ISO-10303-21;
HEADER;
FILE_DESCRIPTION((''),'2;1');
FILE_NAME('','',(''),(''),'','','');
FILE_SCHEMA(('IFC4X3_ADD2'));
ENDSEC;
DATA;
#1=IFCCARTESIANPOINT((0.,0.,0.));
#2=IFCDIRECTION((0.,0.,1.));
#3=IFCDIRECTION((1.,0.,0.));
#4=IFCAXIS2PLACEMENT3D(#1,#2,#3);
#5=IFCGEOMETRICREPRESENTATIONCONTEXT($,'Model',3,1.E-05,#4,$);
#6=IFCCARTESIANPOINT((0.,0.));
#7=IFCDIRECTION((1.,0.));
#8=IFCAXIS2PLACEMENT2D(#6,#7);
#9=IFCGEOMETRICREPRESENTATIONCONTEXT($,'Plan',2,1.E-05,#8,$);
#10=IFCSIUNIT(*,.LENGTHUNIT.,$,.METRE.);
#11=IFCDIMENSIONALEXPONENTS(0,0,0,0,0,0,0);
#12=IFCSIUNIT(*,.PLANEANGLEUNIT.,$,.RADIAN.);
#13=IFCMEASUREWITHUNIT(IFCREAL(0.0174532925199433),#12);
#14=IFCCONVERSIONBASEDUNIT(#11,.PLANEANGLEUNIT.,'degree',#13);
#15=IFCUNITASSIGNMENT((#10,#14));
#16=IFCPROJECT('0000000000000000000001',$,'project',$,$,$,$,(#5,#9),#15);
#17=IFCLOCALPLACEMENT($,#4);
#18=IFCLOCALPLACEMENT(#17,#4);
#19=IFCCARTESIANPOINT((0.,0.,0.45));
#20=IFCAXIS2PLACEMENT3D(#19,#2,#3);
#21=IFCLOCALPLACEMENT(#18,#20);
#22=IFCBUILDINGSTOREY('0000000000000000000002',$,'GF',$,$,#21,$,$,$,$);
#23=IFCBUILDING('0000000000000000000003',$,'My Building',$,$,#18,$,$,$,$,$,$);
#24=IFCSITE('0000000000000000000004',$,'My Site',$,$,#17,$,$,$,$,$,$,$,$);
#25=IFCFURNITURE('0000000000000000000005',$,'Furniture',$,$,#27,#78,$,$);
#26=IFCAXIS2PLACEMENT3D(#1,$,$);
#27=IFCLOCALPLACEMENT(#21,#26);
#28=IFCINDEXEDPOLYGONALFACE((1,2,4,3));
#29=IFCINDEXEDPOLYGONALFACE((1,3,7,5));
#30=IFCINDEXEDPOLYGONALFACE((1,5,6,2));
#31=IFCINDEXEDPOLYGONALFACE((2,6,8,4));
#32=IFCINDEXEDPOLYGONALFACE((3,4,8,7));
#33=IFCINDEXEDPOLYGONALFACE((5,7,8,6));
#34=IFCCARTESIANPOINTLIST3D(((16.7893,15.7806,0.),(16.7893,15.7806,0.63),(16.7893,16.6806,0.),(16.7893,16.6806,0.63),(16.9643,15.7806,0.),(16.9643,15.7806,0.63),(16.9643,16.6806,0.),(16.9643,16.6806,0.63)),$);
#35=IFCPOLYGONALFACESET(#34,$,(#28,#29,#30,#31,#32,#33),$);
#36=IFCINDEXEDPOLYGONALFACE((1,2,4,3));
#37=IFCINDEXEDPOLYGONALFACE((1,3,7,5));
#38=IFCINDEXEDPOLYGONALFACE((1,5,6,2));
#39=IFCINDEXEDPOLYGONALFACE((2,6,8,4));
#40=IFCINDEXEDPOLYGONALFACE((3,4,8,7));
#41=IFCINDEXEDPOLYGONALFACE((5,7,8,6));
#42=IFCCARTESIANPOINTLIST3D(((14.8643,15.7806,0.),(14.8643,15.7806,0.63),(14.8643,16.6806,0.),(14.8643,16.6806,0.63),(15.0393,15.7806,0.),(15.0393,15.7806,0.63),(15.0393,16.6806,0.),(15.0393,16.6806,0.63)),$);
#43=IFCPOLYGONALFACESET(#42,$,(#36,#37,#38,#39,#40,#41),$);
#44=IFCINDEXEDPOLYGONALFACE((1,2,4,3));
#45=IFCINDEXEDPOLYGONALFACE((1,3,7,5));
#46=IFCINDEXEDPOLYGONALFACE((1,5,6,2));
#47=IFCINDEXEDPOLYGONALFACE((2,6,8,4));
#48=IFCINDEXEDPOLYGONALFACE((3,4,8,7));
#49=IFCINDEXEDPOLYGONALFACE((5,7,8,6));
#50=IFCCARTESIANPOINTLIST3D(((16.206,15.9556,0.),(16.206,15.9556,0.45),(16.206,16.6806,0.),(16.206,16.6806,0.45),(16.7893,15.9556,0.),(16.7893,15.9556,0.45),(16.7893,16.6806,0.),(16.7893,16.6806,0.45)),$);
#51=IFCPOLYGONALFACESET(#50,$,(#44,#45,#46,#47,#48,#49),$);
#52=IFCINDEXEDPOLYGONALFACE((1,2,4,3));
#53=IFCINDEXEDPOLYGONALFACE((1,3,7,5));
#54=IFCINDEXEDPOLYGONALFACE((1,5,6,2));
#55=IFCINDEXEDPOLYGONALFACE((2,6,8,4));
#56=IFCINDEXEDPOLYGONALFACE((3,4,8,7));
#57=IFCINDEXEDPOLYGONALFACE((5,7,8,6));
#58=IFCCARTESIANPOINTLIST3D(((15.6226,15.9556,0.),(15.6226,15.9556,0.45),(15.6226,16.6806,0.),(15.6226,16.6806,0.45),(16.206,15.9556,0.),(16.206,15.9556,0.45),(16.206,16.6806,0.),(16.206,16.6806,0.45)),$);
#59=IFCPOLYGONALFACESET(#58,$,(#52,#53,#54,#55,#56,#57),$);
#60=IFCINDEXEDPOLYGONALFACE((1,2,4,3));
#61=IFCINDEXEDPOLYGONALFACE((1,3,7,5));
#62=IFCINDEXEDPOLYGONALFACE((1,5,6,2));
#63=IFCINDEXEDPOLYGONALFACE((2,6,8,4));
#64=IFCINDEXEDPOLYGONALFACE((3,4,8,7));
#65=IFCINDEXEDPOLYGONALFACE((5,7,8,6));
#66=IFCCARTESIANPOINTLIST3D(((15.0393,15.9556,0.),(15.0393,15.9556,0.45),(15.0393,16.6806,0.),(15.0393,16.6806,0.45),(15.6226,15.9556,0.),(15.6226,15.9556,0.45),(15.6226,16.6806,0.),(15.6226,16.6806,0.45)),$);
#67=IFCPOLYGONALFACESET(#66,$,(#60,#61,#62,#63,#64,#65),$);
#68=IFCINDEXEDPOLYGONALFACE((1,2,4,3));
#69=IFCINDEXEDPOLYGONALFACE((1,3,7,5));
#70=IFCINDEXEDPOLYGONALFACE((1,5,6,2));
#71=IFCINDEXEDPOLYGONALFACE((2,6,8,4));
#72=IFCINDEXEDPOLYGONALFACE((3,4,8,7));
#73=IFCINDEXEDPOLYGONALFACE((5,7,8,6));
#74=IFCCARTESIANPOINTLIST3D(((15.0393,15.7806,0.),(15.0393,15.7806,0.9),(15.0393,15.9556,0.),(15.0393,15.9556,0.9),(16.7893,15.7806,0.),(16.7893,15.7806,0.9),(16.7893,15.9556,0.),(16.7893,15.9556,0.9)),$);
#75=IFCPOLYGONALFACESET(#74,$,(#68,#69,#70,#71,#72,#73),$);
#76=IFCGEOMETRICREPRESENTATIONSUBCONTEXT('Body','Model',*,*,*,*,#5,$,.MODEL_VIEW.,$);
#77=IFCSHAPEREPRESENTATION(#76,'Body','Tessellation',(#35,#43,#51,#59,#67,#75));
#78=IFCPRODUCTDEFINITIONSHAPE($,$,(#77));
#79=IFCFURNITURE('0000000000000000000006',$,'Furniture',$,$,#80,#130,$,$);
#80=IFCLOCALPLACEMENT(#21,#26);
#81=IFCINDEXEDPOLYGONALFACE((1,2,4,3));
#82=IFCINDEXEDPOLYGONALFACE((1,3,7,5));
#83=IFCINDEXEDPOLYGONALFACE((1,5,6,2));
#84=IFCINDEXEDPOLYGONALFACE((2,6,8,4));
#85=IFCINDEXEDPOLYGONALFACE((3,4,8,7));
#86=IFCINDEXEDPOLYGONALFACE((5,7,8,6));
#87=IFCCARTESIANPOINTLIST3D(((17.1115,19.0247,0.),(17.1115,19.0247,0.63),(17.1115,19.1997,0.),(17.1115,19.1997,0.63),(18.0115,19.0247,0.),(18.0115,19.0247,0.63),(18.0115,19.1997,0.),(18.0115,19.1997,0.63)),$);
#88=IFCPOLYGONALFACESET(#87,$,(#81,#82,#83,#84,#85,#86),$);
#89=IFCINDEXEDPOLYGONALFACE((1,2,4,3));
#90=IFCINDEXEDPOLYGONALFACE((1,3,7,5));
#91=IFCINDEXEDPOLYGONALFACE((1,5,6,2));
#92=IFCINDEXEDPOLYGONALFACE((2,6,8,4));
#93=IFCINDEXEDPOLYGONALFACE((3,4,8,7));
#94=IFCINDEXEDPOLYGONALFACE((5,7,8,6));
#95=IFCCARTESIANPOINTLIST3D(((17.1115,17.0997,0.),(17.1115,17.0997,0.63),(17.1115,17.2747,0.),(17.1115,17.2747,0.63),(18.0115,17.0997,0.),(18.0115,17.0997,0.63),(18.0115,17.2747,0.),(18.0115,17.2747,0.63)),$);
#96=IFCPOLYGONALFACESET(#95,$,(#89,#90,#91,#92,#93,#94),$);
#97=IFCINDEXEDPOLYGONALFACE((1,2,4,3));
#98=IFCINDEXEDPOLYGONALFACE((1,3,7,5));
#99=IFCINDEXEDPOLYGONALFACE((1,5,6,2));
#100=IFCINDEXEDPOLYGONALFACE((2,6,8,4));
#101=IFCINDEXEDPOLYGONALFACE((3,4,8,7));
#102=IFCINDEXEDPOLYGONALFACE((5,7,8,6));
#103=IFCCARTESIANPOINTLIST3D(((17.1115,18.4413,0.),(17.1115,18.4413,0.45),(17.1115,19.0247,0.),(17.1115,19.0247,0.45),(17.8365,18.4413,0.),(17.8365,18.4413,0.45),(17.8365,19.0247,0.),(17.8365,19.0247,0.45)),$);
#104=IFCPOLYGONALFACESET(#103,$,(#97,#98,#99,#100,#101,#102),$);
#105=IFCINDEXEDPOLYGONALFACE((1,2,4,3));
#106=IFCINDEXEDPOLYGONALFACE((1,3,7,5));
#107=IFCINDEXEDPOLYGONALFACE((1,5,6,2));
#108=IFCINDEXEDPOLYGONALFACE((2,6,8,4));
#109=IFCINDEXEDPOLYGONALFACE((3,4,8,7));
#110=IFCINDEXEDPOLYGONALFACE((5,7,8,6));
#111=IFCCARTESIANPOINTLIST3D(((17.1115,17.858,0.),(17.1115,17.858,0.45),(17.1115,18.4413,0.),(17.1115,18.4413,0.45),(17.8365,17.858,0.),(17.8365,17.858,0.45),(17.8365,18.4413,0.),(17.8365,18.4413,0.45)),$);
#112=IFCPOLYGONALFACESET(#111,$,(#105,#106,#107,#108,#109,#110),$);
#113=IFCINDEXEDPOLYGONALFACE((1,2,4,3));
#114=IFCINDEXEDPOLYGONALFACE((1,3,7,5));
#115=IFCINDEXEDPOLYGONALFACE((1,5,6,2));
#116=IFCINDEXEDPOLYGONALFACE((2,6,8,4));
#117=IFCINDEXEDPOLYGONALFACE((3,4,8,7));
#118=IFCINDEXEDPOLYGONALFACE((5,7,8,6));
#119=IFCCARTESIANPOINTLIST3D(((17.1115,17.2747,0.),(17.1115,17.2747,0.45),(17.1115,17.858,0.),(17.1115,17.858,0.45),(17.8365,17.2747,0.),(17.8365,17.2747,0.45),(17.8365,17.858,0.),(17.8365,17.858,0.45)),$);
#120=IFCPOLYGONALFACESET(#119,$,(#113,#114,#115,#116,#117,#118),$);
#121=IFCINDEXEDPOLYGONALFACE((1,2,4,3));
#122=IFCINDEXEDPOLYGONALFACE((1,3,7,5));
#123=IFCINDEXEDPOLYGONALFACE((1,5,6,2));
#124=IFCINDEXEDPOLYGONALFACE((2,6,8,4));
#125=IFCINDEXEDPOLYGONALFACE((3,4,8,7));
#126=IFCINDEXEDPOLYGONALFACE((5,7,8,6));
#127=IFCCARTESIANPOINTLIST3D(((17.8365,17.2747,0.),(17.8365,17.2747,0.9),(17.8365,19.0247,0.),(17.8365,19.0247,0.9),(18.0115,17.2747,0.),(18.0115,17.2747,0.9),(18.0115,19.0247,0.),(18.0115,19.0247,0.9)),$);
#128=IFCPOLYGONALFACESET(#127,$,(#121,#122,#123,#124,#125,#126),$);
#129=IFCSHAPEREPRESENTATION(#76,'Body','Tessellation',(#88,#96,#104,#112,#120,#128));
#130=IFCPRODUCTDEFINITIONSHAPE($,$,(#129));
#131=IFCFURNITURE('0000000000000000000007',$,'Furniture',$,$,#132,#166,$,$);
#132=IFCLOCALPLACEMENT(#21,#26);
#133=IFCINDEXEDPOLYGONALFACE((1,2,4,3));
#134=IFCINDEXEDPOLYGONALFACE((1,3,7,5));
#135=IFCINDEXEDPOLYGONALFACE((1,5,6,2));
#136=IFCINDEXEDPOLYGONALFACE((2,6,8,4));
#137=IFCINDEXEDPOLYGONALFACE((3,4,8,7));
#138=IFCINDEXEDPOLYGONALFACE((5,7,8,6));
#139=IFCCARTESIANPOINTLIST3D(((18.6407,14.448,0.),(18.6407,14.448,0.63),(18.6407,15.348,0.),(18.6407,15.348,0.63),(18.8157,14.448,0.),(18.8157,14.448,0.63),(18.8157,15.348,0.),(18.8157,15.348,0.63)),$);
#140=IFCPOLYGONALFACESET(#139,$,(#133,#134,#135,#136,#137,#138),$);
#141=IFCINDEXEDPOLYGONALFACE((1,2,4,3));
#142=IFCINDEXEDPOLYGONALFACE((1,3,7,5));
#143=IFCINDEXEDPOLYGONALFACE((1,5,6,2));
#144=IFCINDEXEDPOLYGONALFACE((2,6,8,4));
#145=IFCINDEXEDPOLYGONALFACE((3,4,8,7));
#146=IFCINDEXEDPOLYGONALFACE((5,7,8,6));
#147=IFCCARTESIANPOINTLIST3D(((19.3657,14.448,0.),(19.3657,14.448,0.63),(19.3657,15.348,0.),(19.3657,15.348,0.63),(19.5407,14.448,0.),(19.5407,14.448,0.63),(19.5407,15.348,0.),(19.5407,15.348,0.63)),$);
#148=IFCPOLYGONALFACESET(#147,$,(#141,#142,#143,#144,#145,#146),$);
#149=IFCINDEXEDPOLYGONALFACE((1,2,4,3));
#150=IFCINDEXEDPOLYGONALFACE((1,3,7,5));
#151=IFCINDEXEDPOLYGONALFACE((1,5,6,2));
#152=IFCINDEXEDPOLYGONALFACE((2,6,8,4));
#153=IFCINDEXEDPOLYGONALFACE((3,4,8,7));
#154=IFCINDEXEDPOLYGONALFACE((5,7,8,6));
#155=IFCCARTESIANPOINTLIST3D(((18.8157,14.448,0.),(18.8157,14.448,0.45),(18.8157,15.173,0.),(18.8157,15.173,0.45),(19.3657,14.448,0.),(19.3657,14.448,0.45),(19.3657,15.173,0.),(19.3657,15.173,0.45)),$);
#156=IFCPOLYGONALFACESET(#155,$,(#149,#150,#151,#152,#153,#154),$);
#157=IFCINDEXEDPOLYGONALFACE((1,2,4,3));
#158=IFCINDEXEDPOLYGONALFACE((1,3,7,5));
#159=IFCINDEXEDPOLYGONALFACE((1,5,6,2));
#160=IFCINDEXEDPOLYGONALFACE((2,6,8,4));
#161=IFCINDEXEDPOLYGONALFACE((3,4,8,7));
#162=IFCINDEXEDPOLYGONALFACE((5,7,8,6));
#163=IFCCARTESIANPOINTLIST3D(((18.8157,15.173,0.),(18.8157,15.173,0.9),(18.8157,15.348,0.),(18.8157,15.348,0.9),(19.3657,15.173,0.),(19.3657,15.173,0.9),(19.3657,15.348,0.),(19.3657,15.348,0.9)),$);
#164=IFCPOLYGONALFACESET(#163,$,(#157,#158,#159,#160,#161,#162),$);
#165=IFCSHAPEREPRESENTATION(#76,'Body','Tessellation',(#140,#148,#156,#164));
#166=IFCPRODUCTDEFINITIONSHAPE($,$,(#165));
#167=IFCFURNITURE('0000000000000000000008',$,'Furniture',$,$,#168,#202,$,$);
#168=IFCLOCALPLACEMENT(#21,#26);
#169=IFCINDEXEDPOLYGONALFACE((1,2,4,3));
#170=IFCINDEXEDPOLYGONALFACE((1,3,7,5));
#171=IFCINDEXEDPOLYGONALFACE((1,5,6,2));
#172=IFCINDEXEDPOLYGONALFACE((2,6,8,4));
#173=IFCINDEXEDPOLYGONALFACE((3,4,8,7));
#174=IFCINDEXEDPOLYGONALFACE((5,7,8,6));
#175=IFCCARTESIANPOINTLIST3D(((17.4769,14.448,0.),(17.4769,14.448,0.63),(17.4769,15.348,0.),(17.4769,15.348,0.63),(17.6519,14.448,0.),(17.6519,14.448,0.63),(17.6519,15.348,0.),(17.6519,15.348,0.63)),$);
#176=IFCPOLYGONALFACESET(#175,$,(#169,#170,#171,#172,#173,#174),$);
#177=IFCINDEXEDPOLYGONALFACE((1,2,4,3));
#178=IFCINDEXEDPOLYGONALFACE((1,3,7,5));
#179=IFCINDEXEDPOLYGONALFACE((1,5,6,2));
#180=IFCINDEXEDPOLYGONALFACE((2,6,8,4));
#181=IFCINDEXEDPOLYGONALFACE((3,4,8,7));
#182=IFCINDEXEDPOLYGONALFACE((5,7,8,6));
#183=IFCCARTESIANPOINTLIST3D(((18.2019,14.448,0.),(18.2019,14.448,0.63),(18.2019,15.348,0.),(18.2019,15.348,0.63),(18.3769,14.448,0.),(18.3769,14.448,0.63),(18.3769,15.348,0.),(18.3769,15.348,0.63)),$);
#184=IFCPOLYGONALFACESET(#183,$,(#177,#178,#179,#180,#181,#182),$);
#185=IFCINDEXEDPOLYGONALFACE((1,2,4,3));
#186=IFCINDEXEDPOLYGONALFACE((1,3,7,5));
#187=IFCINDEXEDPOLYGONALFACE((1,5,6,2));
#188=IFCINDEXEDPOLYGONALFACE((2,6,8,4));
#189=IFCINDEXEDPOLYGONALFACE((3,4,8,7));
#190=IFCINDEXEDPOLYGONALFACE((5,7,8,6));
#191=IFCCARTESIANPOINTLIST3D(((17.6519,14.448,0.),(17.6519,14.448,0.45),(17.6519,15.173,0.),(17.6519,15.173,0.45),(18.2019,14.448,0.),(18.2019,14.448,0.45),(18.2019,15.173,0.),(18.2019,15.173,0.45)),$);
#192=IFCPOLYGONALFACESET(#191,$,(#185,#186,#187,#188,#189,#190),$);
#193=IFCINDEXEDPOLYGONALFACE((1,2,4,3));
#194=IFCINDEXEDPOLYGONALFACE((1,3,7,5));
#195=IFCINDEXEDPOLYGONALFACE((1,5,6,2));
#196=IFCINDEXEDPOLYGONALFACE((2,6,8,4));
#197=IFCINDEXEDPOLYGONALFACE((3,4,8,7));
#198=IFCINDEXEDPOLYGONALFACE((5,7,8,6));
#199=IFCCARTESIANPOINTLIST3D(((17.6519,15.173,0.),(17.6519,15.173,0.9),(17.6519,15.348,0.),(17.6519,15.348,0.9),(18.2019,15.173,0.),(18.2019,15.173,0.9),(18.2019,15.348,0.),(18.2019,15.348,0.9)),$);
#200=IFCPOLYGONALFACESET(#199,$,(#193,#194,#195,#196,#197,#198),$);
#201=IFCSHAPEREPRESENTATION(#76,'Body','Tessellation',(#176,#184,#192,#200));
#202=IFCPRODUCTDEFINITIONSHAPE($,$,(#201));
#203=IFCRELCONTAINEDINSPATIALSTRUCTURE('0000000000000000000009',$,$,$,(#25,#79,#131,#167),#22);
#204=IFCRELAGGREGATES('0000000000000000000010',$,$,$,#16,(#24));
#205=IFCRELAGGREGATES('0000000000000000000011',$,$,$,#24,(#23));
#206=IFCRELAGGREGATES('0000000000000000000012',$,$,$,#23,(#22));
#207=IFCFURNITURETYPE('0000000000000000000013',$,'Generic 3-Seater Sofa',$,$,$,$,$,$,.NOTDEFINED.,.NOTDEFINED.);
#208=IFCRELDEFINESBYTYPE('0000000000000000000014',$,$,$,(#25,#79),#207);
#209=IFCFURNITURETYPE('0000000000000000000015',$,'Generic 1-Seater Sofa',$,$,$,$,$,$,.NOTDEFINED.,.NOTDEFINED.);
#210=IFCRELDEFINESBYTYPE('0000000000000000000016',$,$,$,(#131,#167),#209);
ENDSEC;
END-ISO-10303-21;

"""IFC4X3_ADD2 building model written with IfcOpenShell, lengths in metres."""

from ifc_helpers import new_model, entity, si_unit, converted_unit, frame, origin_with_axes, origin_2d_with_axis, place, context, subcontext, project, spatial, line, indexed_curve, outline, extrude, shape, source, transform, mapped, type_object, type_shapes, element, save


model = new_model("IFC4X3_ADD2")

# Units and contexts
model_context = context("Model", 3, precision=1e-05, world=origin_with_axes())
plan_context = context("Plan", 2, precision=1e-05, world=origin_2d_with_axis())
body_context_1 = subcontext(model_context, "Body", "Model", "MODEL_VIEW")
body_context_2 = subcontext(plan_context, "Body", "Plan", "PLAN_VIEW")
ifc_project = project(units=[si_unit("LENGTHUNIT", "METRE"), converted_unit("PLANEANGLEUNIT", "degree", entity("IfcReal", 0.0174532925199433), si_unit("PLANEANGLEUNIT", "RADIAN"), dimensions=[0, 0, 0, 0, 0, 0, 0])], contexts=[model_context, plan_context])

# Site, building, storey
site_placement = place(None, origin_with_axes())
site = spatial("IfcSite", under=ifc_project, at=site_placement, Name="My Site")
building_placement = place(site_placement, origin_with_axes())
building = spatial("IfcBuilding", under=site, at=building_placement, Name="My Building")
storey_placement = place(building_placement, frame((0.0, 0.0, 0.45), z_axis=(0.0, 0.0, 1.0), x_axis=(1.0, 0.0, 0.0)))
storey = spatial("IfcBuildingStorey", under=building, at=storey_placement, Name="GF")

# Furniture
furniture_type_1 = type_object("IfcFurnitureType", Name="Generic 3-Seater Sofa", AssemblyPlace="NOTDEFINED", PredefinedType="NOTDEFINED")
shared_shape_1 = source(origin_with_axes(), body_context_1, "Body", "SweptSolid", [
    extrude(outline(indexed_curve([(0.0, 0.0), (0.175, 0.0), (0.175, 0.9), (0.0, 0.9)], segments=[line(1, 2, 3, 4, 1)])), frame((-1.05, -0.9, 0.0), z_axis=(0.0, 0.0, 1.0), x_axis=(1.0, 0.0, 0.0)), (0.0, 0.0, 1.0), 0.63),
    extrude(outline(indexed_curve([(0.0, 0.0), (0.175, 0.0), (0.175, 0.9), (0.0, 0.9)], segments=[line(1, 2, 3, 4, 1)])), frame((0.875, -0.9, 0.0), z_axis=(0.0, 0.0, 1.0), x_axis=(1.0, 0.0, 0.0)), (0.0, 0.0, 1.0), 0.63),
    extrude(outline(indexed_curve([(0.175, 0.0), (0.7583, 0.0), (0.7583, 0.725), (0.175, 0.725)], segments=[line(1, 2, 3, 4, 1)])), frame((-1.05, -0.9, 0.0), z_axis=(0.0, 0.0, 1.0), x_axis=(1.0, 0.0, 0.0)), (0.0, 0.0, 1.0), 0.45),
    extrude(outline(indexed_curve([(0.7583, 0.0), (1.3417, 0.0), (1.3417, 0.725), (0.7583, 0.725)], segments=[line(1, 2, 3, 4, 1)])), frame((-1.05, -0.9, 0.0), z_axis=(0.0, 0.0, 1.0), x_axis=(1.0, 0.0, 0.0)), (0.0, 0.0, 1.0), 0.45),
    extrude(outline(indexed_curve([(1.3417, 0.0), (1.925, 0.0), (1.925, 0.725), (1.3417, 0.725)], segments=[line(1, 2, 3, 4, 1)])), frame((-1.05, -0.9, 0.0), z_axis=(0.0, 0.0, 1.0), x_axis=(1.0, 0.0, 0.0)), (0.0, 0.0, 1.0), 0.45),
    extrude(outline(indexed_curve([(0.175, 0.725), (1.925, 0.725), (1.925, 0.9), (0.175, 0.9)], segments=[line(1, 2, 3, 4, 1)])), frame((-1.05, -0.9, 0.0), z_axis=(0.0, 0.0, 1.0), x_axis=(1.0, 0.0, 0.0)), (0.0, 0.0, 1.0), 0.9),
])
shared_shape_2 = source(origin_with_axes(), body_context_2, "Body", "Curve2D", [
    entity("IfcIndexedPolyCurve", entity("IfcCartesianPointList2D", [[-1.05, -0.9], [-0.875, -0.9], [-0.875, 0.0], [-1.05, 0.0]]), [entity("IfcLineIndex", [1, 2, 3, 4, 1])]),
    entity("IfcIndexedPolyCurve", entity("IfcCartesianPointList2D", [[0.875, -0.9], [1.05, -0.9], [1.05, 0.0], [0.875, 0.0]]), [entity("IfcLineIndex", [1, 2, 3, 4, 1])]),
    entity("IfcIndexedPolyCurve", entity("IfcCartesianPointList2D", [[-0.875, -0.9], [-0.2917, -0.9], [-0.2917, -0.175], [-0.875, -0.175]]), [entity("IfcLineIndex", [1, 2, 3, 4, 1])]),
    entity("IfcIndexedPolyCurve", entity("IfcCartesianPointList2D", [[-0.2917, -0.9], [0.2917, -0.9], [0.2917, -0.175], [-0.2917, -0.175]]), [entity("IfcLineIndex", [1, 2, 3, 4, 1])]),
    entity("IfcIndexedPolyCurve", entity("IfcCartesianPointList2D", [[0.2917, -0.9], [0.875, -0.9], [0.875, -0.175], [0.2917, -0.175]]), [entity("IfcLineIndex", [1, 2, 3, 4, 1])]),
    entity("IfcIndexedPolyCurve", entity("IfcCartesianPointList2D", [[-0.875, -0.175], [0.875, -0.175], [0.875, 0.0], [-0.875, 0.0]]), [entity("IfcLineIndex", [1, 2, 3, 4, 1])]),
])
type_shapes(furniture_type_1, [shared_shape_1, shared_shape_2])
for number, where, z_axis, x_axis, name in (
    (1, (15.9143, 15.7806, 0.0), (0.0, 0.0, 1.0), (-1.0, 0.0, 0.0), "Furniture"),
    (2, (18.0115, 18.1497, 0.0), (0.0, 0.0, 1.0), (0.0, -1.0, 0.0), "Furniture"),
):
    element("IfcFurniture", number, at=place(storey_placement, frame(where, z_axis=z_axis, x_axis=x_axis)), inside=storey, type_object=furniture_type_1, Name=name, shapes=[
        shape(body_context_1, "Body", "MappedRepresentation", [mapped(shared_shape_1, transform((0.0, 0.0, 0.0), x_axis=(1.0, 0.0, 0.0), y_axis=(0.0, 1.0, 0.0), z_axis=(0.0, 0.0, 1.0), scale=1.0))]),
        shape(body_context_2, "Body", "MappedRepresentation", [mapped(shared_shape_2, transform((0.0, 0.0, 0.0), x_axis=(1.0, 0.0, 0.0), y_axis=(0.0, 1.0, 0.0), z_axis=(0.0, 0.0, 1.0), scale=1.0))]),
    ])
furniture_type_2 = type_object("IfcFurnitureType", Name="Generic 1-Seater Sofa", AssemblyPlace="NOTDEFINED", PredefinedType="NOTDEFINED")
shared_shape_3 = source(origin_with_axes(), body_context_1, "Body", "SweptSolid", [
    extrude(outline(indexed_curve([(0.0, 0.0), (0.175, 0.0), (0.175, 0.9), (0.0, 0.9)], segments=[line(1, 2, 3, 4, 1)])), frame((-0.45, -0.9, 0.0), z_axis=(0.0, 0.0, 1.0), x_axis=(1.0, 0.0, 0.0)), (0.0, 0.0, 1.0), 0.63),
    extrude(outline(indexed_curve([(0.0, 0.0), (0.175, 0.0), (0.175, 0.9), (0.0, 0.9)], segments=[line(1, 2, 3, 4, 1)])), frame((0.275, -0.9, 0.0), z_axis=(0.0, 0.0, 1.0), x_axis=(1.0, 0.0, 0.0)), (0.0, 0.0, 1.0), 0.63),
    extrude(outline(indexed_curve([(0.175, 0.0), (0.725, 0.0), (0.725, 0.725), (0.175, 0.725)], segments=[line(1, 2, 3, 4, 1)])), frame((-0.45, -0.9, 0.0), z_axis=(0.0, 0.0, 1.0), x_axis=(1.0, 0.0, 0.0)), (0.0, 0.0, 1.0), 0.45),
    extrude(outline(indexed_curve([(0.175, 0.725), (0.725, 0.725), (0.725, 0.9), (0.175, 0.9)], segments=[line(1, 2, 3, 4, 1)])), frame((-0.45, -0.9, 0.0), z_axis=(0.0, 0.0, 1.0), x_axis=(1.0, 0.0, 0.0)), (0.0, 0.0, 1.0), 0.9),
])
shared_shape_4 = source(origin_with_axes(), body_context_2, "Body", "Annotation2D", [
    entity("IfcGeometricCurveSet", [entity("IfcIndexedPolyCurve", entity("IfcCartesianPointList2D", [[0.275, -0.175], [0.275, -0.9], [0.45, -0.9], [0.45, 0.0], [0.275, 0.0], [0.275, -0.9], [-0.275, -0.9], [-0.275, 0.0], [-0.275, -0.175], [0.275, -0.175], [0.275, 0.0], [-0.275, 0.0], [-0.45, 0.0], [-0.45, -0.9], [-0.275, -0.9], [-0.275, -0.175]]))]),
])
type_shapes(furniture_type_2, [shared_shape_3, shared_shape_4])
for number, where, z_axis, x_axis, name in (
    (3, (19.0907, 15.348, 0.0), (0.0, 0.0, 1.0), (1.0, 0.0, 0.0), "Furniture"),
    (4, (17.9269, 15.348, 0.0), (0.0, 0.0, 1.0), (1.0, 0.0, 0.0), "Furniture"),
):
    element("IfcFurniture", number, at=place(storey_placement, frame(where, z_axis=z_axis, x_axis=x_axis)), inside=storey, type_object=furniture_type_2, Name=name, shapes=[
        shape(body_context_1, "Body", "MappedRepresentation", [mapped(shared_shape_3, transform((0.0, 0.0, 0.0), x_axis=(1.0, 0.0, 0.0), y_axis=(0.0, 1.0, 0.0), z_axis=(0.0, 0.0, 1.0), scale=1.0))]),
        shape(body_context_2, "Body", "MappedRepresentation", [mapped(shared_shape_4, transform((0.0, 0.0, 0.0), x_axis=(1.0, 0.0, 0.0), y_axis=(0.0, 1.0, 0.0), z_axis=(0.0, 0.0, 1.0), scale=1.0))]),
    ])

save(model, "model.ifc")
